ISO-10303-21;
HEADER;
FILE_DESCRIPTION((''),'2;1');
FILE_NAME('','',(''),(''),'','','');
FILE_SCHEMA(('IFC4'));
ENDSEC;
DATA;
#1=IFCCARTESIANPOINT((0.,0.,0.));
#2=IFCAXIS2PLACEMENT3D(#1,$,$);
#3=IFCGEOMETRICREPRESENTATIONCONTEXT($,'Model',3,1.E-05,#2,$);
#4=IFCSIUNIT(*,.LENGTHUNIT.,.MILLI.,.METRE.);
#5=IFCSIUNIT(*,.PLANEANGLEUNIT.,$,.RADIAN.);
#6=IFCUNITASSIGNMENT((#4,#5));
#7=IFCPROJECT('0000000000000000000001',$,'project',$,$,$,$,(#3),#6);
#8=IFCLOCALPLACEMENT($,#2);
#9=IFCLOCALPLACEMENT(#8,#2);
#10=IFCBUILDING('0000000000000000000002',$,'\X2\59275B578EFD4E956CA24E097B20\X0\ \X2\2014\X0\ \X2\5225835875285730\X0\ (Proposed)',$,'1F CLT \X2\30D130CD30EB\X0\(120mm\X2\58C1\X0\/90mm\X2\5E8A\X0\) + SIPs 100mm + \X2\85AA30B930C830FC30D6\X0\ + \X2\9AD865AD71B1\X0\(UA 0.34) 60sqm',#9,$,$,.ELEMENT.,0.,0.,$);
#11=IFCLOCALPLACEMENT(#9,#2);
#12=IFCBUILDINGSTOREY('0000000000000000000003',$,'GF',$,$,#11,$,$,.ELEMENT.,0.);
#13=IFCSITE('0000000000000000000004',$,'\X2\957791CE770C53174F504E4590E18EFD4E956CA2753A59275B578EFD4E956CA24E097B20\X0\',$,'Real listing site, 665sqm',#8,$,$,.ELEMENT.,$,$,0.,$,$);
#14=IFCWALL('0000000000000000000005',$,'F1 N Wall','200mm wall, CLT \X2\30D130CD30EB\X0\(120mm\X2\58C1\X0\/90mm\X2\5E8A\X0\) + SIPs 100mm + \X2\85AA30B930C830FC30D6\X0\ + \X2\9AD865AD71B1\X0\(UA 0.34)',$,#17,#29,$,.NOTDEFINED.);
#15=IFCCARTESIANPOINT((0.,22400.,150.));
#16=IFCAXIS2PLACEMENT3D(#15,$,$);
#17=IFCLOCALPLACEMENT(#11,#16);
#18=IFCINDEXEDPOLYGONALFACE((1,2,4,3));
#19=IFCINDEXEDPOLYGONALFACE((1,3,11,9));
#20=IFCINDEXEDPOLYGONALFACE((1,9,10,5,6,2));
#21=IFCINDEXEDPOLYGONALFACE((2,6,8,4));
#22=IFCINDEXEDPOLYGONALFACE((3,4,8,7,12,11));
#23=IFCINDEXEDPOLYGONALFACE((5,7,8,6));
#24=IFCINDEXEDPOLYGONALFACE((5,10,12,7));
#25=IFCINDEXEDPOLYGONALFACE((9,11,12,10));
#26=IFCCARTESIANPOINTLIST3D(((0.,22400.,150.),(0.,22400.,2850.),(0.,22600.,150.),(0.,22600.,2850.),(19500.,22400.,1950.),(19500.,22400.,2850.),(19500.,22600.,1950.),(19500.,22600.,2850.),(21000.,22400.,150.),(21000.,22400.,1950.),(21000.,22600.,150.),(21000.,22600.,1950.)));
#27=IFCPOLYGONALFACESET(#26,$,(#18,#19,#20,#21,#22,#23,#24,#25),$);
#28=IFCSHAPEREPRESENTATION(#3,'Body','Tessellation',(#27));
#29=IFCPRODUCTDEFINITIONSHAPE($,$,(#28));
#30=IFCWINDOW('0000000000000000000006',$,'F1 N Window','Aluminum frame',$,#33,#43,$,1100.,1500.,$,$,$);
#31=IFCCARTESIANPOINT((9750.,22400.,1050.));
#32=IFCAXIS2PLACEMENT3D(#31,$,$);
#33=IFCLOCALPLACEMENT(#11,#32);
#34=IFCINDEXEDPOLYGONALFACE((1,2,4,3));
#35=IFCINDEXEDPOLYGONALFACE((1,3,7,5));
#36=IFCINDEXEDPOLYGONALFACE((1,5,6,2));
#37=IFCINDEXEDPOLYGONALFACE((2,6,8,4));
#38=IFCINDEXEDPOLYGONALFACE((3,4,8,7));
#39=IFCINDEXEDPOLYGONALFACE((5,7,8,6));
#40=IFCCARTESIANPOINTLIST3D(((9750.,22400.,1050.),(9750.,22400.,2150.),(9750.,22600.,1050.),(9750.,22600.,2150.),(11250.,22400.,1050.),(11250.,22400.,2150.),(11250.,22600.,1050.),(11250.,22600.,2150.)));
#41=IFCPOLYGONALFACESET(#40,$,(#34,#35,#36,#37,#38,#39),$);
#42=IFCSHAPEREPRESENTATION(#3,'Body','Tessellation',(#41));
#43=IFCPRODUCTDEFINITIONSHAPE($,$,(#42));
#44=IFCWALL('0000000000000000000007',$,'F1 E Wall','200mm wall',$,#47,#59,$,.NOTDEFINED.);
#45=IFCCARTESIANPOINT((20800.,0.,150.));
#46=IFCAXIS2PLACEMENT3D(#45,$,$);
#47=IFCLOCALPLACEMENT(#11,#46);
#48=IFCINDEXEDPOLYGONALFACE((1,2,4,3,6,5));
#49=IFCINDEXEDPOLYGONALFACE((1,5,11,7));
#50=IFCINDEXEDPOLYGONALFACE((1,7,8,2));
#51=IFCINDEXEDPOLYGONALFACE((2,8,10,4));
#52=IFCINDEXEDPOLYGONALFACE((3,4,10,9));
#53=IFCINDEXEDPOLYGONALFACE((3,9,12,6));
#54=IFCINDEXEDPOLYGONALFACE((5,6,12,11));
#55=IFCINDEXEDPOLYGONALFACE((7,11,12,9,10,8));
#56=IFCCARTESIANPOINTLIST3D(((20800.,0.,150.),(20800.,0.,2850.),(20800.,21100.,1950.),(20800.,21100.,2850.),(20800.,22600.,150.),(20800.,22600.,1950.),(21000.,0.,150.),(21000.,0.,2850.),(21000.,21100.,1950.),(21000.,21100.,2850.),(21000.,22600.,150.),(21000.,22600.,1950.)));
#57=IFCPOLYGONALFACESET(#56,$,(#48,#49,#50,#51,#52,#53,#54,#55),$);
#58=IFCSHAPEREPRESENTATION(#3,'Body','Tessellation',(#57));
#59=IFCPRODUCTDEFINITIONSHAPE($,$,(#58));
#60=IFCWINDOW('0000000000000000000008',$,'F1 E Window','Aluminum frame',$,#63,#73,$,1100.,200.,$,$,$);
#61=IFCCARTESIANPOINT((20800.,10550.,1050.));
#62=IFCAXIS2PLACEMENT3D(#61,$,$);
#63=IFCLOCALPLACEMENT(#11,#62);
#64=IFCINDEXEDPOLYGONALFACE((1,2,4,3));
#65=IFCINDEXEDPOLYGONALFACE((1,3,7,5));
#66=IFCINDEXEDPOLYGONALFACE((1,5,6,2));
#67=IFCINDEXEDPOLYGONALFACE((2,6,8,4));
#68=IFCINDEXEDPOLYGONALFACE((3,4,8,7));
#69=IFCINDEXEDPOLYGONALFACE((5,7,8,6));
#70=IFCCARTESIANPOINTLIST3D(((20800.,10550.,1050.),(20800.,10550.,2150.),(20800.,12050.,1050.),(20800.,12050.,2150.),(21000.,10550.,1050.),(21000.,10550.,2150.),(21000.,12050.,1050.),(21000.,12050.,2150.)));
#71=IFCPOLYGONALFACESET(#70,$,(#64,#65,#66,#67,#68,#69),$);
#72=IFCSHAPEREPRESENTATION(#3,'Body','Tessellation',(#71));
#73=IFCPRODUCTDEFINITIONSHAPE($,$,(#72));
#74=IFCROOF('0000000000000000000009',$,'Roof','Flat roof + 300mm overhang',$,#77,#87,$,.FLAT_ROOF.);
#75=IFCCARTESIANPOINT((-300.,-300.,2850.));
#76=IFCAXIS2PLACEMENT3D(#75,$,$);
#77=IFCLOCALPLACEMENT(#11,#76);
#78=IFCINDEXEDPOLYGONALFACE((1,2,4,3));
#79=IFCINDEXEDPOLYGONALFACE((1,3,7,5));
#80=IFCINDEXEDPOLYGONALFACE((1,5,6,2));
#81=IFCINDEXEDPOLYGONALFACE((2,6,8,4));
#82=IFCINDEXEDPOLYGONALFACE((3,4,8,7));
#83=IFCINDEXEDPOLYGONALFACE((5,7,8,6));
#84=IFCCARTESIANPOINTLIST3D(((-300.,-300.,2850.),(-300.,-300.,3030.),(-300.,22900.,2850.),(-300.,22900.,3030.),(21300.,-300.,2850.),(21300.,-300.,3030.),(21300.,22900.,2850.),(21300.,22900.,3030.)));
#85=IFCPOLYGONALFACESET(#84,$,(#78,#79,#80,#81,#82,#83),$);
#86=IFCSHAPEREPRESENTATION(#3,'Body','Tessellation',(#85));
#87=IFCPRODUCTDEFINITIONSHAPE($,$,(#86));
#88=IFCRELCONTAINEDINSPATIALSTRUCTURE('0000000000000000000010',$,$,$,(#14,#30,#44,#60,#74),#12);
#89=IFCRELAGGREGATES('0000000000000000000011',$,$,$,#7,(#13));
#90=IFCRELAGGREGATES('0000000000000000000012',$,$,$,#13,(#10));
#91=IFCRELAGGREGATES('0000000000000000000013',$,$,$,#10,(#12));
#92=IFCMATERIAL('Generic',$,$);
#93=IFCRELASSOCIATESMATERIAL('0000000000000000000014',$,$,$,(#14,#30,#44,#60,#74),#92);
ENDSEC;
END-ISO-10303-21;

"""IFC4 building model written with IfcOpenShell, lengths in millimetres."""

from ifc_helpers import new_model, si_unit, frame, frame_2d, origin, place, context, project, spatial, rectangle, extrude, material, element, fill, save


model = new_model("IFC4")

# Units and contexts
model_context = context("Model", 3, precision=1e-05, world=origin())
ifc_project = project(units=[si_unit("LENGTHUNIT", "METRE", prefix="MILLI"), si_unit("PLANEANGLEUNIT", "RADIAN")], contexts=[model_context])

# Site, building, storey
site_placement = place(None, origin())
site = spatial("IfcSite", under=ifc_project, at=site_placement, Name="長野県北佐久郡軽井沢町大字軽井沢三笠", ObjectType="Real listing site, 665sqm", CompositionType="ELEMENT", RefElevation=0.0)
building_placement = place(site_placement, origin())
building = spatial("IfcBuilding", under=site, at=building_placement, Name="大字軽井沢三笠 — 別荘用地 (Proposed)", ObjectType="1F CLT パネル(120mm壁/90mm床) + SIPs 100mm + 薪ストーブ + 高断熱(UA 0.34) 60sqm", CompositionType="ELEMENT", ElevationOfRefHeight=0.0, ElevationOfTerrain=0.0)
storey_placement = place(building_placement, origin())
storey = spatial("IfcBuildingStorey", under=building, at=storey_placement, Name="GF", CompositionType="ELEMENT", Elevation=0.0)

# Wall, opening, window
ifc_material_1 = material(Name="Generic")
wall_1_placement = place(storey_placement, frame((0.0, 22400.0, 150.0)))
wall_1 = element("IfcWall", 1, at=wall_1_placement, inside=storey, material=ifc_material_1, Name="F1 N Wall", Description="200mm wall, CLT パネル(120mm壁/90mm床) + SIPs 100mm + 薪ストーブ + 高断熱(UA 0.34)", PredefinedType="NOTDEFINED", context=model_context, shape_type="SweptSolid", body=[
    extrude(rectangle(XDim=21000.0, YDim=200.0, at=frame_2d((10500.0, 100.0))), frame((0.0, 22400.0, 150.0)), (0.0, 0.0, 1.0), 2700.0),
])
opening_1_placement = place(storey_placement, frame((9750.0, 22400.0, 1050.0)))
opening_1 = element("IfcOpeningElement", 2, at=opening_1_placement, cuts=wall_1, PredefinedType="NOTDEFINED", context=model_context, shape_type="SweptSolid", body=[
    extrude(rectangle(XDim=1500.0, YDim=200.0, at=frame_2d((750.0, 100.0))), frame((9750.0, 22400.0, 1050.0)), (0.0, 0.0, 1.0), 1100.0),
])
window_1_placement = place(storey_placement, frame((9750.0, 22400.0, 1050.0)))
window_1 = element("IfcWindow", 3, at=window_1_placement, inside=storey, material=ifc_material_1, Name="F1 N Window", Description="Aluminum frame", OverallHeight=1100.0, OverallWidth=1500.0, context=model_context, shape_type="SweptSolid", body=[
    extrude(rectangle(XDim=1500.0, YDim=200.0, at=frame_2d((750.0, 100.0))), frame((9750.0, 22400.0, 1050.0)), (0.0, 0.0, 1.0), 1100.0),
])
fill(opening_1, window_1)

# Wall, opening, window
wall_2_placement = place(storey_placement, frame((20800.0, 0.0, 150.0)))
wall_2 = element("IfcWall", 4, at=wall_2_placement, inside=storey, material=ifc_material_1, Name="F1 E Wall", Description="200mm wall", PredefinedType="NOTDEFINED", context=model_context, shape_type="SweptSolid", body=[
    extrude(rectangle(XDim=200.0, YDim=22600.0, at=frame_2d((100.0, 11300.0))), frame((20800.0, 0.0, 150.0)), (0.0, 0.0, 1.0), 2700.0),
])
opening_2_placement = place(storey_placement, frame((20800.0, 10550.0, 1050.0)))
opening_2 = element("IfcOpeningElement", 5, at=opening_2_placement, cuts=wall_2, PredefinedType="NOTDEFINED", context=model_context, shape_type="SweptSolid", body=[
    extrude(rectangle(XDim=200.0, YDim=1500.0, at=frame_2d((100.0, 750.0))), frame((20800.0, 10550.0, 1050.0)), (0.0, 0.0, 1.0), 1100.0),
])
window_2_placement = place(storey_placement, frame((20800.0, 10550.0, 1050.0)))
window_2 = element("IfcWindow", 6, at=window_2_placement, inside=storey, material=ifc_material_1, Name="F1 E Window", Description="Aluminum frame", OverallHeight=1100.0, OverallWidth=200.0, context=model_context, shape_type="SweptSolid", body=[
    extrude(rectangle(XDim=200.0, YDim=1500.0, at=frame_2d((100.0, 750.0))), frame((20800.0, 10550.0, 1050.0)), (0.0, 0.0, 1.0), 1100.0),
])
fill(opening_2, window_2)

# Roof
roof_placement = place(storey_placement, frame((-300.0, -300.0, 2850.0)))
element("IfcRoof", 7, at=roof_placement, inside=storey, material=ifc_material_1, Name="Roof", Description="Flat roof + 300mm overhang", PredefinedType="FLAT_ROOF", context=model_context, shape_type="SweptSolid", body=[
    extrude(rectangle(XDim=21600.0, YDim=23200.0, at=frame_2d((10800.0, 11600.0))), frame((-300.0, -300.0, 2850.0)), (0.0, 0.0, 1.0), 180.0),
])

save(model, "model.ifc")
